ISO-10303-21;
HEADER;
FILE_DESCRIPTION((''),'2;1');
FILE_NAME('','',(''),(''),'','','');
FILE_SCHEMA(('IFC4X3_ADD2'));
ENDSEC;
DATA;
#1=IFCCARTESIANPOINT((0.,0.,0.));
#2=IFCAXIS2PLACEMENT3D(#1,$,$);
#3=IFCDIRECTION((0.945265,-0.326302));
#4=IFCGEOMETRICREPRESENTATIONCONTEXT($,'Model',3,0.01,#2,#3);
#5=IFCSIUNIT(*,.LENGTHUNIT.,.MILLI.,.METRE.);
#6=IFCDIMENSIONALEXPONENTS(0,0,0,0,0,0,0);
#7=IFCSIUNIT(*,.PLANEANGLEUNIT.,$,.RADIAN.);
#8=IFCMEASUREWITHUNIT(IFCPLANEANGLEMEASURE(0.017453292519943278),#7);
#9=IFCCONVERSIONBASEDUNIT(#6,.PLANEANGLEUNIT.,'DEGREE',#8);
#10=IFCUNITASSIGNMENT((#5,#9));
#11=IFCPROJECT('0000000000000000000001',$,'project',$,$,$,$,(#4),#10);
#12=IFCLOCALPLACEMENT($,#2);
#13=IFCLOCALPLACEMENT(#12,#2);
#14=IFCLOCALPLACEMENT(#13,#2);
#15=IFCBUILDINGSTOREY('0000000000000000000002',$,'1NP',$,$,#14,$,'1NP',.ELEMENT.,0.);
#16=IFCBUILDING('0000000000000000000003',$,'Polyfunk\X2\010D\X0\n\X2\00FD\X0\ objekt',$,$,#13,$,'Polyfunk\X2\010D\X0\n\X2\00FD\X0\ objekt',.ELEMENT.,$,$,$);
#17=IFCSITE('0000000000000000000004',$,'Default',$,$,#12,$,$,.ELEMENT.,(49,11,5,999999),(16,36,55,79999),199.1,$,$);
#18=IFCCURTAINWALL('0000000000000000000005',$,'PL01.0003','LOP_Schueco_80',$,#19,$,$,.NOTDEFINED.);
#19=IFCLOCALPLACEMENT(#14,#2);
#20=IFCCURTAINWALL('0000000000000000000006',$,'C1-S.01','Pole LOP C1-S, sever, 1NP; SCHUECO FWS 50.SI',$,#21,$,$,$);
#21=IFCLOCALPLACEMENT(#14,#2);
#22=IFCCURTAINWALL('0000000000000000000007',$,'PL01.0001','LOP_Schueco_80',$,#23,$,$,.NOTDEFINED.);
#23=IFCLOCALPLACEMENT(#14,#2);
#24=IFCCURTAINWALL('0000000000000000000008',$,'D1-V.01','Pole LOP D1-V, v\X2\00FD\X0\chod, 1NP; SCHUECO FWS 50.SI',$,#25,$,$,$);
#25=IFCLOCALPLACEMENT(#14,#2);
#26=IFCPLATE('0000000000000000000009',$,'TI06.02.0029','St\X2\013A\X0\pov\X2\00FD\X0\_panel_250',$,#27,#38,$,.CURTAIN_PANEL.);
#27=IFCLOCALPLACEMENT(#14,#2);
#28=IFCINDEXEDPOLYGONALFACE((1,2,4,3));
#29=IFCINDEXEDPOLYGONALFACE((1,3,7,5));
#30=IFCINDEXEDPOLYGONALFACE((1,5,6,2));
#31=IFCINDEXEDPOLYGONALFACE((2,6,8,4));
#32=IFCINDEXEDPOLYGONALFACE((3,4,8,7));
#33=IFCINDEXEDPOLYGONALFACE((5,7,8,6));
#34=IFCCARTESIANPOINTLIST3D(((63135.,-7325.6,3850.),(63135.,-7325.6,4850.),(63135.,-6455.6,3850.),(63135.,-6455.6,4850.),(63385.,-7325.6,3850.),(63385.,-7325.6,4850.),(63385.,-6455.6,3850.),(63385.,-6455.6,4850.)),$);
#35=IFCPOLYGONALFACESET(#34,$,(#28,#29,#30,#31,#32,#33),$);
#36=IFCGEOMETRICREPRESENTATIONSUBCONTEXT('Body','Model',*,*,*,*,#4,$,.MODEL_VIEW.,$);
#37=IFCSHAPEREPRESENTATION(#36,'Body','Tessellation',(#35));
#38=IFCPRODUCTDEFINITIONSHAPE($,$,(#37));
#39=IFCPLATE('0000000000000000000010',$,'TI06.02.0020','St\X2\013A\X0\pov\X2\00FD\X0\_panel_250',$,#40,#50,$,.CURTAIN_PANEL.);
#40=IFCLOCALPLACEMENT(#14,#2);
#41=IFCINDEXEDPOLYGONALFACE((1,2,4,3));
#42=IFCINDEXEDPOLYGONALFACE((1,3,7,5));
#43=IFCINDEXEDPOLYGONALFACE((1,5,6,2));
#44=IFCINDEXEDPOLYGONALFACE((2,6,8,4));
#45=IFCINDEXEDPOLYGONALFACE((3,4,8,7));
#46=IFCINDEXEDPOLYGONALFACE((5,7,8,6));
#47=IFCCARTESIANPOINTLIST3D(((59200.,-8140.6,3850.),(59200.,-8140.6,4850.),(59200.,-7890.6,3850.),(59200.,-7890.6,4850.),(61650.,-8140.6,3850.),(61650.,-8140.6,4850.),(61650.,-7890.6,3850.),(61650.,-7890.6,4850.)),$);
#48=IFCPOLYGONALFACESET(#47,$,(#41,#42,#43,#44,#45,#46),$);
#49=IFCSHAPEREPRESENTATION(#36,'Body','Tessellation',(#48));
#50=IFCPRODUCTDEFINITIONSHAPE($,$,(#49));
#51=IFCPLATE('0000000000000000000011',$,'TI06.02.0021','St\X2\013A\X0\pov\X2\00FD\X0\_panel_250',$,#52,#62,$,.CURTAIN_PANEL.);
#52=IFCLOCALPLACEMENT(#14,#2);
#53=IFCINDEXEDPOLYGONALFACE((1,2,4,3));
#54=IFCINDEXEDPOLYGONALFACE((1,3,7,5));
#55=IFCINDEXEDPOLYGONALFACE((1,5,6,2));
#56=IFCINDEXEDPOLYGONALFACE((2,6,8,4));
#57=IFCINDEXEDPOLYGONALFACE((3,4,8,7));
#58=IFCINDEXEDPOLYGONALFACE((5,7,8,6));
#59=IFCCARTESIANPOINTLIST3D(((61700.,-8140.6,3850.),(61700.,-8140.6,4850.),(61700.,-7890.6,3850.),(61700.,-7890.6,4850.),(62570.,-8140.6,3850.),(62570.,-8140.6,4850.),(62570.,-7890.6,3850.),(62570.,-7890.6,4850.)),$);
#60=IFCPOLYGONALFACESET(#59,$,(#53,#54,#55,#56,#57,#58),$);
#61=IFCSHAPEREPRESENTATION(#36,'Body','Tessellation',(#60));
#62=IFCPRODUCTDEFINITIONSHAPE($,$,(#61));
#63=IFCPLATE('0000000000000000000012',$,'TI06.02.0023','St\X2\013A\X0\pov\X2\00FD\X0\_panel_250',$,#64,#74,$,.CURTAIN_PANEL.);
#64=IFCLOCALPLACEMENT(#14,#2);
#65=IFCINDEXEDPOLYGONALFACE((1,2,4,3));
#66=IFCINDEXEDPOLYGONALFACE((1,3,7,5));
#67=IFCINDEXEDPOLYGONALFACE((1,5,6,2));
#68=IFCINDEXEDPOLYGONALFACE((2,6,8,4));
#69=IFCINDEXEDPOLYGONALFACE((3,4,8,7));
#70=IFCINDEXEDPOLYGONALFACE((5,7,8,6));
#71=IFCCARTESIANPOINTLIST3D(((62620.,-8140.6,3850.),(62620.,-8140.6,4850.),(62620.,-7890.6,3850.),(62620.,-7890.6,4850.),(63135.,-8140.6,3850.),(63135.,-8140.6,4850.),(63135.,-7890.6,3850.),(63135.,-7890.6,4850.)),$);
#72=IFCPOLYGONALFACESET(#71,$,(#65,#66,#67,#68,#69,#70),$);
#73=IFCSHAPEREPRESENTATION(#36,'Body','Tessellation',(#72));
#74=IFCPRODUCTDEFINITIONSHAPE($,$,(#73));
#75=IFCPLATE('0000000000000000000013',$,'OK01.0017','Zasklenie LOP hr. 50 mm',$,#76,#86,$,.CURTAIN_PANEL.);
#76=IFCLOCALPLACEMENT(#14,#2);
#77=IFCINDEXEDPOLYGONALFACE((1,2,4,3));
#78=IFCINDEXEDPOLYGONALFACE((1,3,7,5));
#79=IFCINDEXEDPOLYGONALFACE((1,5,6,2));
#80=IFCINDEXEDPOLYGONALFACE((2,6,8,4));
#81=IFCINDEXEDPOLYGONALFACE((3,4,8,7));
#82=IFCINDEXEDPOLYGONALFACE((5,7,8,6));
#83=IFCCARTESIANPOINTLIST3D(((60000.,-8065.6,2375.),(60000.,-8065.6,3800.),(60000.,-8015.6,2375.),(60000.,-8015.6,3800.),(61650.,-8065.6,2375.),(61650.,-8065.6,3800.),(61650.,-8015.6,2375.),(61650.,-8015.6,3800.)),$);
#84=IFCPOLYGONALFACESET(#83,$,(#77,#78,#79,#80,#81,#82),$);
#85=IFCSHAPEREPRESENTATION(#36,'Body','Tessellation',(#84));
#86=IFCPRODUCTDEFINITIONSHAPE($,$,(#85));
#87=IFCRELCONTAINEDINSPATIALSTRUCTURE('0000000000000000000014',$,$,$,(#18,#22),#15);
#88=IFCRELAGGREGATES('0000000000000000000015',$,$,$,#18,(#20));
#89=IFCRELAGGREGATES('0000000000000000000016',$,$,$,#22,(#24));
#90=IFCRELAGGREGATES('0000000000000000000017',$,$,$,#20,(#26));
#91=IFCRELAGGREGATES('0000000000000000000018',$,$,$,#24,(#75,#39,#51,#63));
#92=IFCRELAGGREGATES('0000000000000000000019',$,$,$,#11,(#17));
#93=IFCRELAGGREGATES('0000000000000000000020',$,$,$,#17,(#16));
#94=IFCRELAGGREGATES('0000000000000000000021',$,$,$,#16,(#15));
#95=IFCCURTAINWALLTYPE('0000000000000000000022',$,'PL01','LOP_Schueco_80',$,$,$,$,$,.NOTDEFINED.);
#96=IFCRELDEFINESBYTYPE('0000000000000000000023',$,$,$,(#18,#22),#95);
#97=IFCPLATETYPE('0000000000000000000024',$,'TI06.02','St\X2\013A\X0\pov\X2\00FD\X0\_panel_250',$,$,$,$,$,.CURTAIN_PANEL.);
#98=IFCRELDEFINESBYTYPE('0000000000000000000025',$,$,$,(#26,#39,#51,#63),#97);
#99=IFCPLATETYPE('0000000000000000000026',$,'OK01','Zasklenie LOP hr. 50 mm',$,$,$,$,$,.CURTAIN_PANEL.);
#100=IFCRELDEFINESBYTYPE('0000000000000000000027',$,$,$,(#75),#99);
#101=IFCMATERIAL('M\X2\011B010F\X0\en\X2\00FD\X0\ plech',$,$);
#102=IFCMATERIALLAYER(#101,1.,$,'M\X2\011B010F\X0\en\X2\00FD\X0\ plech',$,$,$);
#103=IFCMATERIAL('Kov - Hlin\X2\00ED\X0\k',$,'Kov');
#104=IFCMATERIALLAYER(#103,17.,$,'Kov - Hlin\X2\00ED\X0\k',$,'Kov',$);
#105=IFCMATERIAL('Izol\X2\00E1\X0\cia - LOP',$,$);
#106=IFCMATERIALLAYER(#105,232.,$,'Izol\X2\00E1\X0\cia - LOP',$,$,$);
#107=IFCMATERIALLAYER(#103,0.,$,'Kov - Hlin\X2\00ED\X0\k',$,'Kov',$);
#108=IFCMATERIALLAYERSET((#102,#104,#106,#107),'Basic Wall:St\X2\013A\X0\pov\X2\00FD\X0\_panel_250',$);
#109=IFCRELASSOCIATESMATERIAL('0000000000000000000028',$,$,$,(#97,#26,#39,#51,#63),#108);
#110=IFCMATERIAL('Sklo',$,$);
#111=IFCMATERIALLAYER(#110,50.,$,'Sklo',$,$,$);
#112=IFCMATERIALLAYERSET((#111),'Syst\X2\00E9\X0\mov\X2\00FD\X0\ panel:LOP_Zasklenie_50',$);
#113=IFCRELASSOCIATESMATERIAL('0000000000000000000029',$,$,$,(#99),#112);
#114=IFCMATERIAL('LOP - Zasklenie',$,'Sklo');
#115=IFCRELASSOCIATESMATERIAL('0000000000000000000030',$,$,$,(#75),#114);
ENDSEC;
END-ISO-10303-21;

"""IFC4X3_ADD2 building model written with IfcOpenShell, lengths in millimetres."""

from ifc_helpers import new_model, entity, si_unit, converted_unit, direction, frame, frame_2d, origin, origin_2d_with_axis, place, context, subcontext, project, spatial, rectangle, extrude, source, transform, mapped, material, layer, layer_set, layer_usage, type_object, type_shapes, element, aggregate, save


model = new_model("IFC4X3_ADD2")

# Units and contexts
model_context = context("Model", 3, precision=0.01, world=origin(), true_north=direction((0.945265, -0.326302)))
body_context = subcontext(model_context, "Body", "Model", "MODEL_VIEW")
ifc_project = project(units=[si_unit("LENGTHUNIT", "METRE", prefix="MILLI"), converted_unit("PLANEANGLEUNIT", "DEGREE", entity("IfcPlaneAngleMeasure", 0.017453292519943278), si_unit("PLANEANGLEUNIT", "RADIAN"), dimensions=[0, 0, 0, 0, 0, 0, 0])], contexts=[model_context])

# Site, building, storey
site_placement = place(None, origin())
site = spatial("IfcSite", under=ifc_project, at=site_placement, Name="Default", CompositionType="ELEMENT", RefLatitude=(49, 11, 5, 999999), RefLongitude=(16, 36, 55, 79999), RefElevation=199.1)
building_placement = place(site_placement, origin())
building = spatial("IfcBuilding", under=site, at=building_placement, Name="Polyfunkčný objekt", LongName="Polyfunkčný objekt", CompositionType="ELEMENT")
storey_placement = place(building_placement, origin())
storey = spatial("IfcBuildingStorey", under=building, at=storey_placement, Name="1NP", LongName="1NP", CompositionType="ELEMENT", Elevation=0.0)

# Curtain walls
curtain_wall_type = type_object("IfcCurtainWallType", Name="PL01", Description="LOP_Schueco_80", PredefinedType="NOTDEFINED")
curtain_wall_1_placement = place(storey_placement, origin())
curtain_wall_1 = element("IfcCurtainWall", 1, at=curtain_wall_1_placement, inside=storey, type_object=curtain_wall_type, Name="PL01.0003", Description="LOP_Schueco_80", PredefinedType="NOTDEFINED")
curtain_wall_2 = element("IfcCurtainWall", 2, Name="C1-S.01", Description="Pole LOP C1-S, sever, 1NP; SCHUECO FWS 50.SI")
aggregate(curtain_wall_1, [curtain_wall_2])
curtain_wall_3_placement = place(storey_placement, origin())
curtain_wall_3 = element("IfcCurtainWall", 3, at=curtain_wall_3_placement, inside=storey, type_object=curtain_wall_type, Name="PL01.0001", Description="LOP_Schueco_80", PredefinedType="NOTDEFINED")
curtain_wall_4 = element("IfcCurtainWall", 4, Name="D1-V.01", Description="Pole LOP D1-V, východ, 1NP; SCHUECO FWS 50.SI")
aggregate(curtain_wall_3, [curtain_wall_4])

# Plates
ifc_material_1 = material(Name="Měďený plech")
ifc_layer_1 = layer(ifc_material_1, 1.0, Name="Měďený plech")
ifc_material_2 = material(Name="Kov - Hliník", Category="Kov")
ifc_layer_2 = layer(ifc_material_2, 17.0, Name="Kov - Hliník", Category="Kov")
ifc_material_3 = material(Name="Izolácia - LOP")
ifc_layer_3 = layer(ifc_material_3, 232.0, Name="Izolácia - LOP")
ifc_layer_4 = layer(ifc_material_2, 0.0, Name="Kov - Hliník", Category="Kov")
ifc_layer_set_1 = layer_set([ifc_layer_1, ifc_layer_2, ifc_layer_3, ifc_layer_4], Name="Basic Wall:Stĺpový_panel_250")
ifc_layer_usage_1 = layer_usage(ifc_layer_set_1, "AXIS2", "NEGATIVE", 125.0)
plate_type_1 = type_object("IfcPlateType", Name="TI06.02", Description="Stĺpový_panel_250", PredefinedType="CURTAIN_PANEL", material=ifc_layer_set_1)
plate_1_placement = place(storey_placement, frame((63260.0, -6455.6, 3850.0), z_axis=(0.0, 0.0, 1.0), x_axis=(0.0, -1.0, 0.0)))
plate_1 = element("IfcPlate", 5, at=plate_1_placement, type_object=plate_type_1, material=ifc_layer_usage_1, Name="TI06.02.0029", Description="Stĺpový_panel_250", PredefinedType="CURTAIN_PANEL", context=body_context, shape_type="SweptSolid", body=[
    extrude(rectangle(XDim=250.0, YDim=870.0, at=frame_2d((0.0, 0.0), x_axis=(1.0, 0.0))), frame((435.0, 0.0, 0.0), z_axis=(0.0, 0.0, 1.0), x_axis=(0.0, 1.0, 0.0)), (0.0, 0.0, 1.0), 1000.0),
])
aggregate(curtain_wall_2, [plate_1])
ifc_layer_usage_2 = layer_usage(ifc_layer_set_1, "AXIS2", "POSITIVE", -125.0)
plate_2_placement = place(storey_placement, frame((59200.0, -8015.6, 3850.0)))
plate_2 = element("IfcPlate", 6, at=plate_2_placement, type_object=plate_type_1, material=ifc_layer_usage_2, Name="TI06.02.0020", Description="Stĺpový_panel_250", PredefinedType="CURTAIN_PANEL", context=body_context, shape_type="SweptSolid", body=[
    extrude(rectangle(XDim=250.0, YDim=2450.0, at=origin_2d_with_axis()), frame((1225.0, 0.0, 0.0), z_axis=(0.0, 0.0, 1.0), x_axis=(0.0, 1.0, 0.0)), (0.0, 0.0, 1.0), 1000.0),
])
ifc_layer_usage_3 = layer_usage(ifc_layer_set_1, "AXIS2", "POSITIVE", -125.0)
plate_3_placement = place(storey_placement, frame((61700.0, -8015.6, 3850.0)))
plate_3 = element("IfcPlate", 7, at=plate_3_placement, type_object=plate_type_1, material=ifc_layer_usage_3, Name="TI06.02.0021", Description="Stĺpový_panel_250", PredefinedType="CURTAIN_PANEL", context=body_context, shape_type="SweptSolid", body=[
    extrude(rectangle(XDim=250.0, YDim=870.0, at=frame_2d((0.0, 0.0), x_axis=(1.0, 0.0))), frame((435.0, 0.0, 0.0), z_axis=(0.0, 0.0, 1.0), x_axis=(0.0, 1.0, 0.0)), (0.0, 0.0, 1.0), 1000.0),
])
ifc_layer_usage_4 = layer_usage(ifc_layer_set_1, "AXIS2", "POSITIVE", -125.0)
plate_4_placement = place(storey_placement, frame((62620.0, -8015.6, 3850.0)))
plate_4 = element("IfcPlate", 8, at=plate_4_placement, type_object=plate_type_1, material=ifc_layer_usage_4, Name="TI06.02.0023", Description="Stĺpový_panel_250", PredefinedType="CURTAIN_PANEL", context=body_context, shape_type="SweptSolid", body=[
    extrude(rectangle(XDim=250.0, YDim=515.0, at=origin_2d_with_axis()), frame((257.5, 0.0, 0.0), z_axis=(0.0, 0.0, 1.0), x_axis=(0.0, 1.0, 0.0)), (0.0, 0.0, 1.0), 1000.0),
])
ifc_material_4 = material(Name="LOP - Zasklenie", Category="Sklo")
ifc_material_5 = material(Name="Sklo")
ifc_layer_5 = layer(ifc_material_5, 50.0, Name="Sklo")
ifc_layer_set_2 = layer_set([ifc_layer_5], Name="Systémový panel:LOP_Zasklenie_50")
plate_type_2 = type_object("IfcPlateType", Name="OK01", Description="Zasklenie LOP hr. 50 mm", PredefinedType="CURTAIN_PANEL", material=ifc_layer_set_2)
shared_shape_1 = source(origin(), body_context, "Body", "SweptSolid", [
    extrude(rectangle(XDim=1425.0, YDim=1650.0, at=frame_2d((87.6, 0.0), x_axis=(1.0, 0.0))), frame((0.0, -50.0, 624.9), z_axis=(0.0, 1.0, 0.0), x_axis=(0.0, 0.0, 1.0)), (0.0, 0.0, 1.0), 50.0),
])
type_shapes(plate_type_2, [shared_shape_1])
plate_5_placement = place(curtain_wall_3_placement, frame((60825.0, -8015.6, 2375.0)))
plate_5 = element("IfcPlate", 9, at=plate_5_placement, type_object=plate_type_2, material=ifc_material_4, Name="OK01.0017", Description="Zasklenie LOP hr. 50 mm", PredefinedType="CURTAIN_PANEL", context=body_context, shape_type="MappedRepresentation", body=[
    mapped(shared_shape_1, transform((0.0, 0.0, 0.0), scale=1.0)),
])
aggregate(curtain_wall_4, [plate_5, plate_2, plate_3, plate_4])

save(model, "model.ifc")
